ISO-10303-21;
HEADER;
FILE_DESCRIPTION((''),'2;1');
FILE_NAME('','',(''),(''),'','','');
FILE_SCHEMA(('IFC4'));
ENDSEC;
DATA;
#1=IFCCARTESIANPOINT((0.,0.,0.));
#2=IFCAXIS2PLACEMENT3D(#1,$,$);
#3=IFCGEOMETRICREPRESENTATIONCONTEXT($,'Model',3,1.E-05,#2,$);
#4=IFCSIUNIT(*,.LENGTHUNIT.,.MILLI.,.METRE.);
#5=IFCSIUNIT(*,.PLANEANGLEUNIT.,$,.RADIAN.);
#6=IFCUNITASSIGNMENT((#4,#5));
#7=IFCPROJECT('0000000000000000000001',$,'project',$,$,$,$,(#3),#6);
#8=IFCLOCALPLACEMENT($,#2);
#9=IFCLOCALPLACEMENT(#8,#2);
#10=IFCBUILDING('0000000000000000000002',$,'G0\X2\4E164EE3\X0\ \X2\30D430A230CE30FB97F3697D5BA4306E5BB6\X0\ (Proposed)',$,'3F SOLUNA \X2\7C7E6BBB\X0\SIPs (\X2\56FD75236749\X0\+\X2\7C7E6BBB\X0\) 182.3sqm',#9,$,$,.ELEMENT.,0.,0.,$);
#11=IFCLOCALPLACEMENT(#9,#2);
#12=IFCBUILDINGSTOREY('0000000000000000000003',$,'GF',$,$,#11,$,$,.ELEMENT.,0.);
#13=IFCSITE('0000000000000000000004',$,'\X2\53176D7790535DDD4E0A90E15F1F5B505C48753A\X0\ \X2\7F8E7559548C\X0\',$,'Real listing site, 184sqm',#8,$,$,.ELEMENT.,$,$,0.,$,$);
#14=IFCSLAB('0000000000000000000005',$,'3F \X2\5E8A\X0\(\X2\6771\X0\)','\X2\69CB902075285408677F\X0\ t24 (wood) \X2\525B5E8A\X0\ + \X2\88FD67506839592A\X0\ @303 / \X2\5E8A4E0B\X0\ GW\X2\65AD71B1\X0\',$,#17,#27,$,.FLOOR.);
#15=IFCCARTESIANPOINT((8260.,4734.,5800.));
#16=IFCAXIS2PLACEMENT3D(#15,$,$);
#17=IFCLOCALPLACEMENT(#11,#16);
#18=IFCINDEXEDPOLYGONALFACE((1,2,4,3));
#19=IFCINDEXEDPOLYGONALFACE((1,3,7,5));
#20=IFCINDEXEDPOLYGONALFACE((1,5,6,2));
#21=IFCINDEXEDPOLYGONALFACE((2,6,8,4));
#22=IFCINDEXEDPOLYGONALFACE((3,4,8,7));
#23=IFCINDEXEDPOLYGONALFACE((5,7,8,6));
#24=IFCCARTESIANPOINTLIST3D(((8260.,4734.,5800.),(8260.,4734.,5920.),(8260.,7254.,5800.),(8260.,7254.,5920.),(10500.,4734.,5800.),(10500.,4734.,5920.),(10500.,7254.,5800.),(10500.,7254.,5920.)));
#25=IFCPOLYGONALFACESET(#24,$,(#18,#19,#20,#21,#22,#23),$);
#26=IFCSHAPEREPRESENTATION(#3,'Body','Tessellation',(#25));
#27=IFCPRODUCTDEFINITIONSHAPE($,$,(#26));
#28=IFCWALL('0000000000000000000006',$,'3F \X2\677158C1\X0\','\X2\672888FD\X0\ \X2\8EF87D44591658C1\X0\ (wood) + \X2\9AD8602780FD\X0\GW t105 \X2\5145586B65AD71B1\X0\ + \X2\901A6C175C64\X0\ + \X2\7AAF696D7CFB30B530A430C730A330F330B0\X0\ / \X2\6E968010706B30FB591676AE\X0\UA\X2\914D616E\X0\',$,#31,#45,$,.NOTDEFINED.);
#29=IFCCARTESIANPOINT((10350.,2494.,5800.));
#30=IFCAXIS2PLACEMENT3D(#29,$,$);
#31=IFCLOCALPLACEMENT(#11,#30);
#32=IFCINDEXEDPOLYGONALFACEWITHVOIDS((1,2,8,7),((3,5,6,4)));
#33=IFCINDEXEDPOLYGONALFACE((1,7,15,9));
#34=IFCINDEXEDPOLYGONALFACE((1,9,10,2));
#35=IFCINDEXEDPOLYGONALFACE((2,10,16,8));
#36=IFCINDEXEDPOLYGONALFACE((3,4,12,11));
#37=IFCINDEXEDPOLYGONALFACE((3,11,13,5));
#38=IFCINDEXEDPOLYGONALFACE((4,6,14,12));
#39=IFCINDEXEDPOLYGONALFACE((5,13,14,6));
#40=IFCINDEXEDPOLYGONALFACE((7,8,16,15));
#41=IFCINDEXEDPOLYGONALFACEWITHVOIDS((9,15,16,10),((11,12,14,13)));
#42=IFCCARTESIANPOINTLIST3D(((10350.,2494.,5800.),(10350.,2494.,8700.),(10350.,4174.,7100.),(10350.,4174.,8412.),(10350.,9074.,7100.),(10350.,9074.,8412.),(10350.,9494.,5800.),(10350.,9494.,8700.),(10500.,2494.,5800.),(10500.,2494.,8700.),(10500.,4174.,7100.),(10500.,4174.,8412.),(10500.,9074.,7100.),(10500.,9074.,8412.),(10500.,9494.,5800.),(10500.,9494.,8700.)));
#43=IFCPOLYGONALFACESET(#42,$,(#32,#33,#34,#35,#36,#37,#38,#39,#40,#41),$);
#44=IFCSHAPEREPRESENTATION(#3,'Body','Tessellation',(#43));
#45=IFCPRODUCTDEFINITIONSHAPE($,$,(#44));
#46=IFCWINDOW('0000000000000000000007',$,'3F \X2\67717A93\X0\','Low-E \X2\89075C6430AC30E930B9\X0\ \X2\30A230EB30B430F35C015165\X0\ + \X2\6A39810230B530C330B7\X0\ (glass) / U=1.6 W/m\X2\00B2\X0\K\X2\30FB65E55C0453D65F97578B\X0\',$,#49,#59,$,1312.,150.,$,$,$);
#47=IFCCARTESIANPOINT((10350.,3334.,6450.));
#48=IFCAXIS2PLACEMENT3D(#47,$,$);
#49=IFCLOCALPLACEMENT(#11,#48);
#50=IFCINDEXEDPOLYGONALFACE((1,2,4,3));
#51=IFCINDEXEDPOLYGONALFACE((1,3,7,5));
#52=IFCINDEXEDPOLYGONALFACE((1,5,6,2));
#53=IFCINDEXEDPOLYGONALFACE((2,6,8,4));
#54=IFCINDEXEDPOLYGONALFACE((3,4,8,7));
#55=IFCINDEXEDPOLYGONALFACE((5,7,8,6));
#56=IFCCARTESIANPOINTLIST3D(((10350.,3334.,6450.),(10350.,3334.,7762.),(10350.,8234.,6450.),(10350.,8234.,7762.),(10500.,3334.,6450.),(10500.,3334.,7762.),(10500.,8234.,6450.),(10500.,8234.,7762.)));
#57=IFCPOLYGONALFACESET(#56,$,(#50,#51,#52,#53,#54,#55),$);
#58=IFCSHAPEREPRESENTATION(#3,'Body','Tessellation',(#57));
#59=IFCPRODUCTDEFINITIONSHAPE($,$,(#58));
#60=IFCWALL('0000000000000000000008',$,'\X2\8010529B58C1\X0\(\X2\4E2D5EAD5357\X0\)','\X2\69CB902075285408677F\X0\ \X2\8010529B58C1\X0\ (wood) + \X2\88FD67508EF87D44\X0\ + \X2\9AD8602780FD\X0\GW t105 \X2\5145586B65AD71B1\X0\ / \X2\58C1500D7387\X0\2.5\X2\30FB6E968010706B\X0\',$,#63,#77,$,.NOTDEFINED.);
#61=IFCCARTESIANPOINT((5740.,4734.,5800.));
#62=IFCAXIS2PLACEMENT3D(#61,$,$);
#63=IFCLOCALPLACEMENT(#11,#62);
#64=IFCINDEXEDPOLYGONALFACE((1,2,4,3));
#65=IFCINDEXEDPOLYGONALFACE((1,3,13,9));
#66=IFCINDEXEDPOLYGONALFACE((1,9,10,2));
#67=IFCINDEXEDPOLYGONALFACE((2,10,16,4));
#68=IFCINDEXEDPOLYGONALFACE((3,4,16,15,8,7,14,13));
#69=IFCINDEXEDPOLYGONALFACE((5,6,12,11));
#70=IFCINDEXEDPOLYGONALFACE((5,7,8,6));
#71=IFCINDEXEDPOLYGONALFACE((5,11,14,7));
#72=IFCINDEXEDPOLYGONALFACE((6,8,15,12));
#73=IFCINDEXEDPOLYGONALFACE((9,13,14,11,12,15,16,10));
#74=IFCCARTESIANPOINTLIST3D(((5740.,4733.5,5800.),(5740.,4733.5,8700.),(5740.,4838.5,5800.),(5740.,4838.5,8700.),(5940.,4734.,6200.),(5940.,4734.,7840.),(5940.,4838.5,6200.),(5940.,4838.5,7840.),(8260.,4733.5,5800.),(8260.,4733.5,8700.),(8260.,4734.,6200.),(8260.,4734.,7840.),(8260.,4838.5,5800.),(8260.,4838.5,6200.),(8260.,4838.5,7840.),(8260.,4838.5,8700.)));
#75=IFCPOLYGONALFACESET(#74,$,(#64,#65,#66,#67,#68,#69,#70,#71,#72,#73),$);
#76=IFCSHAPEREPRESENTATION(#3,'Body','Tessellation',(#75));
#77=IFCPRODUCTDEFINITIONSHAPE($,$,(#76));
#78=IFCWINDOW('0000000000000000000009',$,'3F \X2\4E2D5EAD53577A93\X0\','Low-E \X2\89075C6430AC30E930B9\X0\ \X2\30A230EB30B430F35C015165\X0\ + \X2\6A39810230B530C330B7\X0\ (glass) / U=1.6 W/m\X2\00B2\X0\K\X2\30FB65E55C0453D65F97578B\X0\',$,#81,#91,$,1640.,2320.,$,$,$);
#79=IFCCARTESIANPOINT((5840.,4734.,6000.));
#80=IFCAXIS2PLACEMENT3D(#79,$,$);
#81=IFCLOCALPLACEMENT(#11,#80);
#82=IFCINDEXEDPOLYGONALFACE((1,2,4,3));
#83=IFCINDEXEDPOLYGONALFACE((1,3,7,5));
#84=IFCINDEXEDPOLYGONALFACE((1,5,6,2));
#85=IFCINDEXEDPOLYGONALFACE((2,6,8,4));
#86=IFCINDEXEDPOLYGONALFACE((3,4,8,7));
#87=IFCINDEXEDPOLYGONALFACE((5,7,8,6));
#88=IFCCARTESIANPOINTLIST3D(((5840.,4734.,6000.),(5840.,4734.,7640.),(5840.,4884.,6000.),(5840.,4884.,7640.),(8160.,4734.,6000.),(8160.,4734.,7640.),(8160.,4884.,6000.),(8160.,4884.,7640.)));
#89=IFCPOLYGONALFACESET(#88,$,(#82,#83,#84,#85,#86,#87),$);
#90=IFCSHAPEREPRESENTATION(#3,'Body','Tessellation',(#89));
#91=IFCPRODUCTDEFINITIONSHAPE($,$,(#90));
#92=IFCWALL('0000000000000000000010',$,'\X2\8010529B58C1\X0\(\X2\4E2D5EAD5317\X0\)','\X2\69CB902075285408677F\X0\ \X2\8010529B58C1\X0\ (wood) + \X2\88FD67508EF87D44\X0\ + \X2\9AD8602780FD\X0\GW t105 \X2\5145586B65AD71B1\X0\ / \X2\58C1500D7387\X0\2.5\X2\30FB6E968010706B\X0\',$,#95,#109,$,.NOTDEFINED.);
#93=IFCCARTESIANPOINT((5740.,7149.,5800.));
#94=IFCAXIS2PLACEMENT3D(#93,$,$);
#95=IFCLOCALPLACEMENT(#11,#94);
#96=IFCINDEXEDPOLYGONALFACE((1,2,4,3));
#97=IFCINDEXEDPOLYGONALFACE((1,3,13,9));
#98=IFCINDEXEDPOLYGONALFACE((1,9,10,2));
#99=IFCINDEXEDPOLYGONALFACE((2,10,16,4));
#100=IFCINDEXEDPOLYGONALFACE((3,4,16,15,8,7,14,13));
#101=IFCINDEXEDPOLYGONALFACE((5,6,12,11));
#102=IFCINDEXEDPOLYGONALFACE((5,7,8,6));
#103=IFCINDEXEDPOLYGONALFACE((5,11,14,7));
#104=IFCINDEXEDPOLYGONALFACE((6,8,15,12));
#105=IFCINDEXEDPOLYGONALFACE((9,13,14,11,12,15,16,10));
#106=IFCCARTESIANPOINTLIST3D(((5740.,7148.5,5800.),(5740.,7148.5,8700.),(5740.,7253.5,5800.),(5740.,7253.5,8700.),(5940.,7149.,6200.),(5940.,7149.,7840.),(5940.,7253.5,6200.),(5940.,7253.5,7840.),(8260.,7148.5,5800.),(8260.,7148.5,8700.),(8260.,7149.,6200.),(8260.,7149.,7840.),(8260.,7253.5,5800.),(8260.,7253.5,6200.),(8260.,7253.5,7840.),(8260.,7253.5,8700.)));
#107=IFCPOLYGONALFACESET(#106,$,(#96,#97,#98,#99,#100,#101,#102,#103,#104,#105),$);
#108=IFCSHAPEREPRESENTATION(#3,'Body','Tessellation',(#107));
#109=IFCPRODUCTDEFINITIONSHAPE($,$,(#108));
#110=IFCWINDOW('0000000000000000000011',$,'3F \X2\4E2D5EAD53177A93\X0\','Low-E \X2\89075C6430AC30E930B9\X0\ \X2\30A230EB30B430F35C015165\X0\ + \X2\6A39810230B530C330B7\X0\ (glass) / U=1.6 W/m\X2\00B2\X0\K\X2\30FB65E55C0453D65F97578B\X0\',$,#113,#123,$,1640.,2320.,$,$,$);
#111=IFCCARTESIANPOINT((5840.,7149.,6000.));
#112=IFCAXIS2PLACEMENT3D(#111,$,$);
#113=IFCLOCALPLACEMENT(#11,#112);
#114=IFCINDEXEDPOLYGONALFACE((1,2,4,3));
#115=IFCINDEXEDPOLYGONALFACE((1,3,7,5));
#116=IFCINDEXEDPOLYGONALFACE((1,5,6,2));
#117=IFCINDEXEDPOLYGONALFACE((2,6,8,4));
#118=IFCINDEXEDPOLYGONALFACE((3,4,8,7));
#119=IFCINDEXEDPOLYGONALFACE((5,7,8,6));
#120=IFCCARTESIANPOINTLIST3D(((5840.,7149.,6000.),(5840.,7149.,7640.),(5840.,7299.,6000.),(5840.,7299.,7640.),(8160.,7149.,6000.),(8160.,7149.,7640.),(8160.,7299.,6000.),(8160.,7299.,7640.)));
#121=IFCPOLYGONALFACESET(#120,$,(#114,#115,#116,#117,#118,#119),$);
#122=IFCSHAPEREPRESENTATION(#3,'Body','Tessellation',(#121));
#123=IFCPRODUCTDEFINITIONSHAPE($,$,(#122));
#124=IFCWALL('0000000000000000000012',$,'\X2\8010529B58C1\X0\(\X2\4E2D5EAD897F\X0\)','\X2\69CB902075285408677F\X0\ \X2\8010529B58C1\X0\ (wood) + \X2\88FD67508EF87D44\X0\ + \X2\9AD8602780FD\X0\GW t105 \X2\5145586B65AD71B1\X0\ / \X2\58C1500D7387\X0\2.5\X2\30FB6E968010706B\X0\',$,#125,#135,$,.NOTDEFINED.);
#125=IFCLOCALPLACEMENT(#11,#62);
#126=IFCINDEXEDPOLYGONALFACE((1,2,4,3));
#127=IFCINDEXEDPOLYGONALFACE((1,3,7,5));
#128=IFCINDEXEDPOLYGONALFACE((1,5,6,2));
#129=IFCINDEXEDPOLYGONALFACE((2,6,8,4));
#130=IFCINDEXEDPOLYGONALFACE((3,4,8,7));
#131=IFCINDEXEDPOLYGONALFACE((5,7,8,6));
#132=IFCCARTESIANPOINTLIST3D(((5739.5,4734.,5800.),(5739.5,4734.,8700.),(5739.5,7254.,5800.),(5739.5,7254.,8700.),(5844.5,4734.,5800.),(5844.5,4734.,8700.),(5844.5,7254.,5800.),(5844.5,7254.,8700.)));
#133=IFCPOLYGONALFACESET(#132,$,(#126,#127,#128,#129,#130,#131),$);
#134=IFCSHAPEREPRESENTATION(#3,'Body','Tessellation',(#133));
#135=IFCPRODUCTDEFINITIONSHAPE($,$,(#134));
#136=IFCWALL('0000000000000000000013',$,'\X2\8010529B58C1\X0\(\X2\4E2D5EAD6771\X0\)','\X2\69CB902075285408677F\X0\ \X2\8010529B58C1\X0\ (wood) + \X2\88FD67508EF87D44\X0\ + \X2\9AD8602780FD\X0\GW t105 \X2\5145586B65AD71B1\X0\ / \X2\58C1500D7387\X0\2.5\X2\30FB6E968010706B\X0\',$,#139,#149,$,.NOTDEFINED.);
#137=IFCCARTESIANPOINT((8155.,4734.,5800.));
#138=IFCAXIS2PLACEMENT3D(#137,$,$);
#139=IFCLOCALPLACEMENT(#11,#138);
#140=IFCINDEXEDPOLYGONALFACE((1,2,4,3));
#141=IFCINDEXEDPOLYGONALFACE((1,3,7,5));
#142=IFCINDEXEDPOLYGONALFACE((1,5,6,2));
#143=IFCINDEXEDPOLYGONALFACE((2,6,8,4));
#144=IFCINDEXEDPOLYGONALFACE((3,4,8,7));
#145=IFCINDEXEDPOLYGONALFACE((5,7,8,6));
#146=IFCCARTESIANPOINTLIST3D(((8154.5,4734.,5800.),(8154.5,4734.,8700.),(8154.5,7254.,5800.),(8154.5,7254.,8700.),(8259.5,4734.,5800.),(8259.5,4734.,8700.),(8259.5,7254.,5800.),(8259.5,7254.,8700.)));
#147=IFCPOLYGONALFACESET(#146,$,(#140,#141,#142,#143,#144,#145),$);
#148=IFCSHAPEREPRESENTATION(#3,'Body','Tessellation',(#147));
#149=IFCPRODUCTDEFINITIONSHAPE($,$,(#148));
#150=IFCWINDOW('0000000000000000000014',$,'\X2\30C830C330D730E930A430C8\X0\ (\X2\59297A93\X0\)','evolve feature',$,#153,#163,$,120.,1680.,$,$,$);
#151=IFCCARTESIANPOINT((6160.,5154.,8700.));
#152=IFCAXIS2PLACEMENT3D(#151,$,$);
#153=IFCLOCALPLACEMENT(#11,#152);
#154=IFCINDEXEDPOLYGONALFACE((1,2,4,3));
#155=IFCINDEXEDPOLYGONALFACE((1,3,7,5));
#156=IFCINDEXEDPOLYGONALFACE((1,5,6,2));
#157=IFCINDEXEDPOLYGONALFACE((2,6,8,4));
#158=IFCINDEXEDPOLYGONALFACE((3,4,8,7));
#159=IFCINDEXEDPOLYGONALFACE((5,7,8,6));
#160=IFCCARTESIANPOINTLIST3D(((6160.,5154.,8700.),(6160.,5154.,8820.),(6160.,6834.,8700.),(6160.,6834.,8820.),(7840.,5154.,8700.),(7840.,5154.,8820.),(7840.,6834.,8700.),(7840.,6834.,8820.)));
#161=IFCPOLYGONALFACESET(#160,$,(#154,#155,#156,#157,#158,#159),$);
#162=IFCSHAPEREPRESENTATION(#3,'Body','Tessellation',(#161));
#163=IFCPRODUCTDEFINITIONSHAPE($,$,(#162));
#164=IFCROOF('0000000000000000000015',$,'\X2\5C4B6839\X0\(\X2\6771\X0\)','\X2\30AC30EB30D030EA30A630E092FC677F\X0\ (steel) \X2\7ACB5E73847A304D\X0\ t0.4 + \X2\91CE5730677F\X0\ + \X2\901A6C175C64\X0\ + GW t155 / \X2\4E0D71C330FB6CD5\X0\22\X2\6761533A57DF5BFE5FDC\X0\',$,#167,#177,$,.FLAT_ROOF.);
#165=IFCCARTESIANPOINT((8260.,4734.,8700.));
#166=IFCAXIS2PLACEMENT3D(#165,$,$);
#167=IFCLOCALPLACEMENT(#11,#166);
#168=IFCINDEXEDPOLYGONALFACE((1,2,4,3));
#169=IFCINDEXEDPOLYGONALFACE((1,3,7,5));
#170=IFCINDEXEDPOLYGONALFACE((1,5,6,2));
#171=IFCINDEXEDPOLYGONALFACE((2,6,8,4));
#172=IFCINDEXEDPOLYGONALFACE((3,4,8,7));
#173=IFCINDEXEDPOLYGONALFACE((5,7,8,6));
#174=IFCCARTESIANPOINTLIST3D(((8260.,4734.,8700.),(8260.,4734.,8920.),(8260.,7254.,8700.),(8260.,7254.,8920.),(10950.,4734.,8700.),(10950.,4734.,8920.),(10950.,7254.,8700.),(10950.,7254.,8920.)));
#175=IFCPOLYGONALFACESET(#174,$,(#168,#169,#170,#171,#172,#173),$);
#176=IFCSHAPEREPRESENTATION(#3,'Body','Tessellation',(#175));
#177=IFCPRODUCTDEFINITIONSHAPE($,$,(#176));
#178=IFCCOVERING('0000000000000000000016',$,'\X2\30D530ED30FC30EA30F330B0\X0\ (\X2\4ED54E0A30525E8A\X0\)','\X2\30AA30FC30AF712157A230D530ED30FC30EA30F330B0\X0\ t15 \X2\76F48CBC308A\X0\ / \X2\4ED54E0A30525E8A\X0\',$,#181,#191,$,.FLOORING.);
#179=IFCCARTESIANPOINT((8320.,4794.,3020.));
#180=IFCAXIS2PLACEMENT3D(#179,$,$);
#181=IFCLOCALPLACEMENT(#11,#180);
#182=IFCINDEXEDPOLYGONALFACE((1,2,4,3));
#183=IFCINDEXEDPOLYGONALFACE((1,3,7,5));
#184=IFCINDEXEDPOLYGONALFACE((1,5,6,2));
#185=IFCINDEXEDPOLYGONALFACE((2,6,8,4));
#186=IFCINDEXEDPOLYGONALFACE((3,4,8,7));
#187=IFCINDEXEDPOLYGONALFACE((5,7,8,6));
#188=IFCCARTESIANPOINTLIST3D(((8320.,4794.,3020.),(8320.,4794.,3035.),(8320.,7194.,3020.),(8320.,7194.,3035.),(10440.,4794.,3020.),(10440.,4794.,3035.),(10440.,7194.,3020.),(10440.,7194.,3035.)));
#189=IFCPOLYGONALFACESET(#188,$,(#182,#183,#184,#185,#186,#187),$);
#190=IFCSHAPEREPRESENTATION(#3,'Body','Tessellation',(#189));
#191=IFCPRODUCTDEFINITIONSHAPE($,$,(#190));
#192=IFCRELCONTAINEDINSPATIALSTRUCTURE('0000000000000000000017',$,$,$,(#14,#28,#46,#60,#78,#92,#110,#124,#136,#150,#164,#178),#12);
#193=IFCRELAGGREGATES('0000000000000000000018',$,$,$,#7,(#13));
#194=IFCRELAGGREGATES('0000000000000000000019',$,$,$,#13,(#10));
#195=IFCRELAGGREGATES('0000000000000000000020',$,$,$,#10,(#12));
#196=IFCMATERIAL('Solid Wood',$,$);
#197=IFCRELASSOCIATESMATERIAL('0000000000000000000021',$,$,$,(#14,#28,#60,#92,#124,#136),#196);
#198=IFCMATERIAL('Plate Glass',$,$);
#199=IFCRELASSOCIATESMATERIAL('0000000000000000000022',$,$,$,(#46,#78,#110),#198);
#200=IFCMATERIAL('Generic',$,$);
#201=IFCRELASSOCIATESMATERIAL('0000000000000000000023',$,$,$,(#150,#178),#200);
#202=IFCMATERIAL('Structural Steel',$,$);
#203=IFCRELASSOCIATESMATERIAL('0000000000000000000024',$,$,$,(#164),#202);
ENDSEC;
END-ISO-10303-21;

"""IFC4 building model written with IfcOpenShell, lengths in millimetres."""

from ifc_helpers import new_model, si_unit, frame, frame_2d, origin, place, context, project, spatial, rectangle, extrude, material, element, fill, save


model = new_model("IFC4")

# Units and contexts
model_context = context("Model", 3, precision=1e-05, world=origin())
ifc_project = project(units=[si_unit("LENGTHUNIT", "METRE", prefix="MILLI"), si_unit("PLANEANGLEUNIT", "RADIAN")], contexts=[model_context])

# Site, building, storey
site_placement = place(None, origin())
site = spatial("IfcSite", under=ifc_project, at=site_placement, Name="北海道川上郡弟子屈町 美留和", ObjectType="Real listing site, 184sqm", CompositionType="ELEMENT", RefElevation=0.0)
building_placement = place(site_placement, origin())
building = spatial("IfcBuilding", under=site, at=building_placement, Name="G0世代 ピアノ・音楽室の家 (Proposed)", ObjectType="3F SOLUNA 籾殻SIPs (国産杉+籾殻) 182.3sqm", CompositionType="ELEMENT", ElevationOfRefHeight=0.0, ElevationOfTerrain=0.0)
storey_placement = place(building_placement, origin())
storey = spatial("IfcBuildingStorey", under=building, at=storey_placement, Name="GF", CompositionType="ELEMENT", Elevation=0.0)

# Slab
ifc_material_1 = material(Name="Solid Wood")
slab_placement = place(storey_placement, frame((8260.0, 4734.0, 5800.0)))
element("IfcSlab", 1, at=slab_placement, inside=storey, material=ifc_material_1, Name="3F 床(東)", Description="構造用合板 t24 (wood) 剛床 + 製材根太 @303 / 床下 GW断熱", PredefinedType="FLOOR", context=model_context, shape_type="SweptSolid", body=[
    extrude(rectangle(XDim=2240.0, YDim=2520.0, at=frame_2d((1120.0, 1260.0))), frame((8260.0, 4734.0, 5800.0)), (0.0, 0.0, 1.0), 120.0),
])

# Walls, openings, windows
wall_1_placement = place(storey_placement, frame((10350.0, 2494.0, 5800.0)))
wall_1 = element("IfcWall", 2, at=wall_1_placement, inside=storey, material=ifc_material_1, Name="3F 東壁", Description="木製 軸組外壁 (wood) + 高性能GW t105 充填断熱 + 通気層 + 窯業系サイディング / 準耐火・外皮UA配慮", PredefinedType="NOTDEFINED", context=model_context, shape_type="SweptSolid", body=[
    extrude(rectangle(XDim=150.0, YDim=7000.0, at=frame_2d((75.0, 3500.0))), frame((10350.0, 2494.0, 5800.0)), (0.0, 0.0, 1.0), 2900.0),
])
opening_1_placement = place(storey_placement, frame((10350.0, 3334.0, 6450.0)))
opening_1 = element("IfcOpeningElement", 3, at=opening_1_placement, cuts=wall_1, PredefinedType="NOTDEFINED", context=model_context, shape_type="SweptSolid", body=[
    extrude(rectangle(XDim=150.0, YDim=4900.0, at=frame_2d((75.0, 2450.0))), frame((10350.0, 3334.0, 6450.0)), (0.0, 0.0, 1.0), 1312.0),
])
ifc_material_2 = material(Name="Plate Glass")
window_1_placement = place(storey_placement, frame((10350.0, 3334.0, 6450.0)))
window_1 = element("IfcWindow", 4, at=window_1_placement, inside=storey, material=ifc_material_2, Name="3F 東窓", Description="Low-E 複層ガラス アルゴン封入 + 樹脂サッシ (glass) / U=1.6 W/m²K・日射取得型", OverallHeight=1312.0, OverallWidth=150.0, context=model_context, shape_type="SweptSolid", body=[
    extrude(rectangle(XDim=150.0, YDim=4900.0, at=frame_2d((75.0, 2450.0))), frame((10350.0, 3334.0, 6450.0)), (0.0, 0.0, 1.0), 1312.0),
])
fill(opening_1, window_1)
wall_2_placement = place(storey_placement, frame((5740.0, 4734.0, 5800.0)))
wall_2 = element("IfcWall", 5, at=wall_2_placement, inside=storey, material=ifc_material_1, Name="耐力壁(中庭南)", Description="構造用合板 耐力壁 (wood) + 製材軸組 + 高性能GW t105 充填断熱 / 壁倍率2.5・準耐火", PredefinedType="NOTDEFINED", context=model_context, shape_type="SweptSolid", body=[
    extrude(rectangle(XDim=2520.0, YDim=105.0, at=frame_2d((1260.0, 52.0))), frame((5740.0, 4734.0, 5800.0)), (0.0, 0.0, 1.0), 2900.0),
])
opening_2_placement = place(storey_placement, frame((5840.0, 4734.0, 6000.0)))
opening_2 = element("IfcOpeningElement", 6, at=opening_2_placement, cuts=wall_2, PredefinedType="NOTDEFINED", context=model_context, shape_type="SweptSolid", body=[
    extrude(rectangle(XDim=2320.0, YDim=150.0, at=frame_2d((1160.0, 75.0))), frame((5840.0, 4734.0, 6000.0)), (0.0, 0.0, 1.0), 1640.0),
])
window_2_placement = place(storey_placement, frame((5840.0, 4734.0, 6000.0)))
window_2 = element("IfcWindow", 7, at=window_2_placement, inside=storey, material=ifc_material_2, Name="3F 中庭南窓", Description="Low-E 複層ガラス アルゴン封入 + 樹脂サッシ (glass) / U=1.6 W/m²K・日射取得型", OverallHeight=1640.0, OverallWidth=2320.0, context=model_context, shape_type="SweptSolid", body=[
    extrude(rectangle(XDim=2320.0, YDim=150.0, at=frame_2d((1160.0, 75.0))), frame((5840.0, 4734.0, 6000.0)), (0.0, 0.0, 1.0), 1640.0),
])
fill(opening_2, window_2)
wall_3_placement = place(storey_placement, frame((5740.0, 7149.0, 5800.0)))
wall_3 = element("IfcWall", 8, at=wall_3_placement, inside=storey, material=ifc_material_1, Name="耐力壁(中庭北)", Description="構造用合板 耐力壁 (wood) + 製材軸組 + 高性能GW t105 充填断熱 / 壁倍率2.5・準耐火", PredefinedType="NOTDEFINED", context=model_context, shape_type="SweptSolid", body=[
    extrude(rectangle(XDim=2520.0, YDim=105.0, at=frame_2d((1260.0, 52.0))), frame((5740.0, 7149.0, 5800.0)), (0.0, 0.0, 1.0), 2900.0),
])
opening_3_placement = place(storey_placement, frame((5840.0, 7149.0, 6000.0)))
opening_3 = element("IfcOpeningElement", 9, at=opening_3_placement, cuts=wall_3, PredefinedType="NOTDEFINED", context=model_context, shape_type="SweptSolid", body=[
    extrude(rectangle(XDim=2320.0, YDim=150.0, at=frame_2d((1160.0, 75.0))), frame((5840.0, 7149.0, 6000.0)), (0.0, 0.0, 1.0), 1640.0),
])
window_3_placement = place(storey_placement, frame((5840.0, 7149.0, 6000.0)))
window_3 = element("IfcWindow", 10, at=window_3_placement, inside=storey, material=ifc_material_2, Name="3F 中庭北窓", Description="Low-E 複層ガラス アルゴン封入 + 樹脂サッシ (glass) / U=1.6 W/m²K・日射取得型", OverallHeight=1640.0, OverallWidth=2320.0, context=model_context, shape_type="SweptSolid", body=[
    extrude(rectangle(XDim=2320.0, YDim=150.0, at=frame_2d((1160.0, 75.0))), frame((5840.0, 7149.0, 6000.0)), (0.0, 0.0, 1.0), 1640.0),
])
fill(opening_3, window_3)

# Walls
wall_4_placement = place(storey_placement, frame((5740.0, 4734.0, 5800.0)))
element("IfcWall", 11, at=wall_4_placement, inside=storey, material=ifc_material_1, Name="耐力壁(中庭西)", Description="構造用合板 耐力壁 (wood) + 製材軸組 + 高性能GW t105 充填断熱 / 壁倍率2.5・準耐火", PredefinedType="NOTDEFINED", context=model_context, shape_type="SweptSolid", body=[
    extrude(rectangle(XDim=105.0, YDim=2520.0, at=frame_2d((52.0, 1260.0))), frame((5740.0, 4734.0, 5800.0)), (0.0, 0.0, 1.0), 2900.0),
])
wall_5_placement = place(storey_placement, frame((8155.0, 4734.0, 5800.0)))
element("IfcWall", 12, at=wall_5_placement, inside=storey, material=ifc_material_1, Name="耐力壁(中庭東)", Description="構造用合板 耐力壁 (wood) + 製材軸組 + 高性能GW t105 充填断熱 / 壁倍率2.5・準耐火", PredefinedType="NOTDEFINED", context=model_context, shape_type="SweptSolid", body=[
    extrude(rectangle(XDim=105.0, YDim=2520.0, at=frame_2d((52.0, 1260.0))), frame((8155.0, 4734.0, 5800.0)), (0.0, 0.0, 1.0), 2900.0),
])

# Window
ifc_material_3 = material(Name="Generic")
window_4_placement = place(storey_placement, frame((6160.0, 5154.0, 8700.0)))
element("IfcWindow", 13, at=window_4_placement, inside=storey, material=ifc_material_3, Name="トップライト (天窓)", Description="evolve feature", OverallHeight=120.0, OverallWidth=1680.0, context=model_context, shape_type="SweptSolid", body=[
    extrude(rectangle(XDim=1680.0, YDim=1680.0, at=frame_2d((840.0, 840.0))), frame((6160.0, 5154.0, 8700.0)), (0.0, 0.0, 1.0), 120.0),
])

# Roof
ifc_material_4 = material(Name="Structural Steel")
for number, where, name in (
    (14, (8260.0, 4734.0, 8700.0), "屋根(東)"),
):
    element("IfcRoof", number, at=place(storey_placement, frame(where)), inside=storey, material=ifc_material_4, Name=name, Description="ガルバリウム鋼板 (steel) 立平葺き t0.4 + 野地板 + 通気層 + GW t155 / 不燃・法22条区域対応", PredefinedType="FLAT_ROOF", context=model_context, shape_type="SweptSolid", body=[
        extrude(rectangle(XDim=2690.0, YDim=2520.0, at=frame_2d((1345.0, 1260.0))), frame((8260.0, 4734.0, 8700.0)), (0.0, 0.0, 1.0), 220.0),
    ])

# Covering
covering_1_placement = place(storey_placement, frame((8320.0, 4794.0, 3020.0)))
element("IfcCovering", 15, at=covering_1_placement, inside=storey, material=ifc_material_3, Name="フローリング (仕上げ床)", Description="オーク無垢フローリング t15 直貼り / 仕上げ床", PredefinedType="FLOORING", context=model_context, shape_type="SweptSolid", body=[
    extrude(rectangle(XDim=2120.0, YDim=2400.0, at=frame_2d((1060.0, 1200.0))), frame((8320.0, 4794.0, 3020.0)), (0.0, 0.0, 1.0), 15.0),
])

save(model, "model.ifc")
